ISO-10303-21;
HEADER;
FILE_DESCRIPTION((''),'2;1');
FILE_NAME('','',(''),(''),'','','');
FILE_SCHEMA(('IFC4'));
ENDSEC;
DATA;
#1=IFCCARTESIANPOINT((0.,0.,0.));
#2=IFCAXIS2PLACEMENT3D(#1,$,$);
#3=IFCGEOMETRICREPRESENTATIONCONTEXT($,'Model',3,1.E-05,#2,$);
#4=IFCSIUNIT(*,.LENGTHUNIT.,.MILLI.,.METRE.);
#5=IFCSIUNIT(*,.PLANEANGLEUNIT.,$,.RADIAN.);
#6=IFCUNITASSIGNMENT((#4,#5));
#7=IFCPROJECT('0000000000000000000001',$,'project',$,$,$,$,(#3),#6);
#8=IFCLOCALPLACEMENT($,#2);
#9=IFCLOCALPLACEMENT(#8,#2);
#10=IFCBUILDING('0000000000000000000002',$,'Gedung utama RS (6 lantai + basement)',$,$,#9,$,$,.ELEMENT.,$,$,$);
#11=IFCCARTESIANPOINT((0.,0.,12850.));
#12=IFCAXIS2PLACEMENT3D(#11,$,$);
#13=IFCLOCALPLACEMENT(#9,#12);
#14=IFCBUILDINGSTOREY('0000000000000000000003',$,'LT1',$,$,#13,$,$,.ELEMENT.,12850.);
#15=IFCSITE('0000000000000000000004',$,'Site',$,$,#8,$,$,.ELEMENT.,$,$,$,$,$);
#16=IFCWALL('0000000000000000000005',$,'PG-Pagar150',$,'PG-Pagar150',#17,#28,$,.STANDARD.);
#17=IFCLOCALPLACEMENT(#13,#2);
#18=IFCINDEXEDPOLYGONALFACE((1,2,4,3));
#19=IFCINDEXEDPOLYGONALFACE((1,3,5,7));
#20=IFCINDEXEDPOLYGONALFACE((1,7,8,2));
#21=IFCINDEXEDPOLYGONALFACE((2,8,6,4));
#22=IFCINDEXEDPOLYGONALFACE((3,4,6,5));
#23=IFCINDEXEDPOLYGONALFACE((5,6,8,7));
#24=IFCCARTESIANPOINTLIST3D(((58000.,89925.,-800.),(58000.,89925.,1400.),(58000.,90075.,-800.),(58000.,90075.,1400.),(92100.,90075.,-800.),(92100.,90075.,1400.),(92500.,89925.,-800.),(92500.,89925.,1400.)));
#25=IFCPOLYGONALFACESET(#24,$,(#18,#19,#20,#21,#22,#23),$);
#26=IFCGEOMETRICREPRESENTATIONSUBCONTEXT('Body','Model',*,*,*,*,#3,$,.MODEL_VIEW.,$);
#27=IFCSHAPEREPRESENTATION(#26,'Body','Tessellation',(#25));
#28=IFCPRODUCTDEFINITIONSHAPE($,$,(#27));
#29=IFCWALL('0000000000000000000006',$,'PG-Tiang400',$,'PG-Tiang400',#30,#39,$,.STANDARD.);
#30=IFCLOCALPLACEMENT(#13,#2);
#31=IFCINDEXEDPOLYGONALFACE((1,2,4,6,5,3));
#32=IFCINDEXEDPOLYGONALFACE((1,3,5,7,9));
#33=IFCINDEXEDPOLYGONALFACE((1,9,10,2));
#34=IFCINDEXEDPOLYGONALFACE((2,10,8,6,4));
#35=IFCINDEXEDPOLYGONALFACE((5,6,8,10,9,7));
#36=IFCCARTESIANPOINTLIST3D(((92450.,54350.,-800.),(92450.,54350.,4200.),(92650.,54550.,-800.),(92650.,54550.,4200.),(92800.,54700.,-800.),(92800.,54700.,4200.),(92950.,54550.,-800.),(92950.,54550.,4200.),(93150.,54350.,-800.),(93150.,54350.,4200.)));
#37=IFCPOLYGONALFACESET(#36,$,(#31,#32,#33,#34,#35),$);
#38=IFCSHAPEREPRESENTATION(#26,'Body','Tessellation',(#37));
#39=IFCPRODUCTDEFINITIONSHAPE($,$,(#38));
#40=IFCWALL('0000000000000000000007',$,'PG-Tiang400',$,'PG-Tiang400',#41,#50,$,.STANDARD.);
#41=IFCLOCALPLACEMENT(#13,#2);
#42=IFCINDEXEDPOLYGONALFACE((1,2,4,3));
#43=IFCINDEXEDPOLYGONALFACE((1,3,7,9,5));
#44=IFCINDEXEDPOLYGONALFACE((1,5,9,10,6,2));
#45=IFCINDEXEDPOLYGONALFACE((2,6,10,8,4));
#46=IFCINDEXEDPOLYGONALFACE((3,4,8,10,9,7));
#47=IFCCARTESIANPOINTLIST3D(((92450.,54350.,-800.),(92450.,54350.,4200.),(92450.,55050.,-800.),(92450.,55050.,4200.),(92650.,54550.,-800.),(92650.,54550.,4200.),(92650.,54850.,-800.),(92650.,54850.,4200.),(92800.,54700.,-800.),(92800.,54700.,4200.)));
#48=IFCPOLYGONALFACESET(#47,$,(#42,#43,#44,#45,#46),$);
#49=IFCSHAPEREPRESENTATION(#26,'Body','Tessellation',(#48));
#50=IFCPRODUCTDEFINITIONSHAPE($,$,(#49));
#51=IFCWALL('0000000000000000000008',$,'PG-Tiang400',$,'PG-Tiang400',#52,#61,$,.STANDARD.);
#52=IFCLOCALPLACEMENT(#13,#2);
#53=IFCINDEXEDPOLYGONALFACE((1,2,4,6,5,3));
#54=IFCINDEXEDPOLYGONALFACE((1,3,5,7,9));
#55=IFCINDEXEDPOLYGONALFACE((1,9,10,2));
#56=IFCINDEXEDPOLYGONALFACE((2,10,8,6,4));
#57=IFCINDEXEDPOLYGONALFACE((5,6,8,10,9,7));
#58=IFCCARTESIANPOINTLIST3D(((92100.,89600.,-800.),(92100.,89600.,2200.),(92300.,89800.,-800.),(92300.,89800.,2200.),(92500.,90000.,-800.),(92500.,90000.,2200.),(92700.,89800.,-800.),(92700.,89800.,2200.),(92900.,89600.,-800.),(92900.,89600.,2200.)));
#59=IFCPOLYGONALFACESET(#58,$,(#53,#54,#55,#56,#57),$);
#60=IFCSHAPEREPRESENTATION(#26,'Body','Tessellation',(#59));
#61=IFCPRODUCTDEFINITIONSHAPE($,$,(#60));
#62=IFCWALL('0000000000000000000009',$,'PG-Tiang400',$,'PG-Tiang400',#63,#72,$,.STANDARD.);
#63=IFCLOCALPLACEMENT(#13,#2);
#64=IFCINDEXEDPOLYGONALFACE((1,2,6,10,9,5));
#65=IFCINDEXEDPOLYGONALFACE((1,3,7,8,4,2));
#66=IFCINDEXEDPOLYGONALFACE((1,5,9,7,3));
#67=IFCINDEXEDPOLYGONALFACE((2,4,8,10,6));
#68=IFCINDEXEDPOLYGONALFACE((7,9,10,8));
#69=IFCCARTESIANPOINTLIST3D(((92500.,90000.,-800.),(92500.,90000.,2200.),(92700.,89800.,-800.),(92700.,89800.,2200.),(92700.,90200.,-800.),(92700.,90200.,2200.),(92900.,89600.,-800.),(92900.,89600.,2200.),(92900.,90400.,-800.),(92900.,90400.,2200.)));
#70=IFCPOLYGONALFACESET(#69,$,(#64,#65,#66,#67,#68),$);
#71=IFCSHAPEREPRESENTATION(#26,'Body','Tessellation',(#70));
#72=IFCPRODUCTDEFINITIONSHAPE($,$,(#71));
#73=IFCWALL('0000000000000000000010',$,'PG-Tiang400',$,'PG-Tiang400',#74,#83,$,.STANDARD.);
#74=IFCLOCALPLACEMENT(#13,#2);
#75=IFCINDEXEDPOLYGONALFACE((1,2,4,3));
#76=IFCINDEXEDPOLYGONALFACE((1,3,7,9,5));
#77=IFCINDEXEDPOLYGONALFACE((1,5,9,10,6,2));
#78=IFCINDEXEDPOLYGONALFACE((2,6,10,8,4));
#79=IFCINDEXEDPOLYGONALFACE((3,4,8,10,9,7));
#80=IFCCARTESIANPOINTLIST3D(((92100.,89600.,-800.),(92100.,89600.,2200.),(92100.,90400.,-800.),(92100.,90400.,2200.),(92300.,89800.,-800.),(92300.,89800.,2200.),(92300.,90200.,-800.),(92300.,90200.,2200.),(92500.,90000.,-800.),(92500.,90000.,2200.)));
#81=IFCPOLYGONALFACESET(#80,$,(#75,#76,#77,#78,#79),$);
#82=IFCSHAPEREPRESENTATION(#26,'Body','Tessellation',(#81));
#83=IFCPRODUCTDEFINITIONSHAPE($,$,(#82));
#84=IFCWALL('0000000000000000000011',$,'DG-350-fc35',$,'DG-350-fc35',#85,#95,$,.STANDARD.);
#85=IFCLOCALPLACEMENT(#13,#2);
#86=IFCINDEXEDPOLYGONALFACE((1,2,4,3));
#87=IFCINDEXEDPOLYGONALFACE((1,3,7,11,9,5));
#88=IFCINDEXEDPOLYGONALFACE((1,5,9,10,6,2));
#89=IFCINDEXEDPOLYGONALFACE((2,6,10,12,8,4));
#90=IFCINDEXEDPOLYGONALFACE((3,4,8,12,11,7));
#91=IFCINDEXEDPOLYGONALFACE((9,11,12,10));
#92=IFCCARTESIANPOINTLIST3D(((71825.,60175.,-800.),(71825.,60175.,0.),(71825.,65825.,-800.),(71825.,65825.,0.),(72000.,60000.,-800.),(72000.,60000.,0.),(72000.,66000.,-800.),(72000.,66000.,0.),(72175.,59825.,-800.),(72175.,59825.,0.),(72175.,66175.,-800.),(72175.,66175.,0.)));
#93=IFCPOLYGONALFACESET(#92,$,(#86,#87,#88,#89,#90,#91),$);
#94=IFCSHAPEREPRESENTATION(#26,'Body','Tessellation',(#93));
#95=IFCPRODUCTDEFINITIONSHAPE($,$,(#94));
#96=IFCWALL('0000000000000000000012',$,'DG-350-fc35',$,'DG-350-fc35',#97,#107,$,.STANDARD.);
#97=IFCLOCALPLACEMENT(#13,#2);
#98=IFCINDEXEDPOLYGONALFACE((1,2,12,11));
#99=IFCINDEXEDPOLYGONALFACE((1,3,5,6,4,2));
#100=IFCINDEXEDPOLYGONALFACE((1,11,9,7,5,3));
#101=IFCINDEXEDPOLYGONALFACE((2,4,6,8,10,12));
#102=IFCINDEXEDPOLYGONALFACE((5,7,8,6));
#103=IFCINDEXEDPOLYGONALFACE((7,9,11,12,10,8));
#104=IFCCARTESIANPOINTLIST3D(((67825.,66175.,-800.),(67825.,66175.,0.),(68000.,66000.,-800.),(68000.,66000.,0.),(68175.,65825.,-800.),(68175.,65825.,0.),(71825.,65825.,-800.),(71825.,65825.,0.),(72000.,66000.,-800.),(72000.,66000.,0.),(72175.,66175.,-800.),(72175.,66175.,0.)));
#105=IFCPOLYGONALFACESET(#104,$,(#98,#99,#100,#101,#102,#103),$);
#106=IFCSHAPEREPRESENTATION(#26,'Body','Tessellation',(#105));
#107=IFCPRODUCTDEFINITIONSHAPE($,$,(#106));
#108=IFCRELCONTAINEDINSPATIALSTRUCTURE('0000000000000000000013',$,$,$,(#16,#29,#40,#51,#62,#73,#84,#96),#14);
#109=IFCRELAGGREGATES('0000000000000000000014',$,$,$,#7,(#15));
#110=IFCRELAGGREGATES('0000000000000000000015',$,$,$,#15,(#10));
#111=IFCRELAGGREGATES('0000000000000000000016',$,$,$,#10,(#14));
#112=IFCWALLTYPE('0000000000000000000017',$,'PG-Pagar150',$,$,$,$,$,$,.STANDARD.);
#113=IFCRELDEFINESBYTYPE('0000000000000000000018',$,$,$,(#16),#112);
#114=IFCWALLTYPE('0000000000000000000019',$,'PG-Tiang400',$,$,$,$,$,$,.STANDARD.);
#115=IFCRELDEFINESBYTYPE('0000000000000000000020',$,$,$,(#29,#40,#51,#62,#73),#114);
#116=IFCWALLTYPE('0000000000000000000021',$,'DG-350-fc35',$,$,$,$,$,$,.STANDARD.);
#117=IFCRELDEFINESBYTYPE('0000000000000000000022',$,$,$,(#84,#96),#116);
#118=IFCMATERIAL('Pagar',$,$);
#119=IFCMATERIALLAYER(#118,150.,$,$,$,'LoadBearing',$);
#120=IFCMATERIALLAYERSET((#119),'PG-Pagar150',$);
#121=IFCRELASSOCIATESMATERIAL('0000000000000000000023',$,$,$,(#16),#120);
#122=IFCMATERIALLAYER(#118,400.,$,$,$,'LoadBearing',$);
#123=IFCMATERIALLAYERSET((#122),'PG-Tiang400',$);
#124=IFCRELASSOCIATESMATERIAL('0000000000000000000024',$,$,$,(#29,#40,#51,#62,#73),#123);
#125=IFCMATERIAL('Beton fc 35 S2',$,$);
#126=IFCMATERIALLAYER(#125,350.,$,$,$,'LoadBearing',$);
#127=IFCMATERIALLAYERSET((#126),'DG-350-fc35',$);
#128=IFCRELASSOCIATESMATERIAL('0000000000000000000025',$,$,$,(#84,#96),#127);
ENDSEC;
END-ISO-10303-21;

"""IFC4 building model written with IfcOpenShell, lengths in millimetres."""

from ifc_helpers import new_model, si_unit, frame, origin, place, context, subcontext, project, spatial, polyline, outline, extrude, material, layer, layer_set, layer_usage, type_object, element, save


model = new_model("IFC4")

# Units and contexts
model_context = context("Model", 3, precision=1e-05, world=origin())
body_context = subcontext(model_context, "Body", "Model", "MODEL_VIEW")
ifc_project = project(units=[si_unit("LENGTHUNIT", "METRE", prefix="MILLI"), si_unit("PLANEANGLEUNIT", "RADIAN")], contexts=[model_context])

# Site, building, storey
site_placement = place(None, origin())
site = spatial("IfcSite", under=ifc_project, at=site_placement, Name="Site", CompositionType="ELEMENT")
building_placement = place(site_placement, origin())
building = spatial("IfcBuilding", under=site, at=building_placement, Name="Gedung utama RS (6 lantai + basement)", CompositionType="ELEMENT")
storey_placement = place(building_placement, frame((0.0, 0.0, 12850.0)))
storey = spatial("IfcBuildingStorey", under=building, at=storey_placement, Name="LT1", CompositionType="ELEMENT", Elevation=12850.0)

# Shared definitions
ifc_material_1 = material(Name="Beton fc 35 S2")

# Walls
ifc_material_2 = material(Name="Pagar")
ifc_layer_1 = layer(ifc_material_2, 150.0, Category="LoadBearing")
ifc_layer_set_1 = layer_set([ifc_layer_1], Name="PG-Pagar150")
ifc_layer_usage_1 = layer_usage(ifc_layer_set_1, "AXIS2", "NEGATIVE", 75.0)
wall_type_1 = type_object("IfcWallType", Name="PG-Pagar150", PredefinedType="STANDARD")
wall_1_placement = place(storey_placement, frame((92500.0, 90000.0, -800.0), z_axis=(0.0, 0.0, 1.0), x_axis=(-1.0, 0.0, 0.0)))
element("IfcWall", 1, at=wall_1_placement, inside=storey, type_object=wall_type_1, material=ifc_layer_usage_1, Name="PG-Pagar150", ObjectType="PG-Pagar150", PredefinedType="STANDARD", context=body_context, shape_type="SweptSolid", body=[
    extrude(outline(polyline([(400.0, -75.0), (0.0, 75.0), (34500.0, 75.0), (34500.0, -75.0), (400.0, -75.0)])), origin(), (0.0, 0.0, 1.0), 2200.0),
])
ifc_layer_2 = layer(ifc_material_2, 400.0, Category="LoadBearing")
ifc_layer_set_2 = layer_set([ifc_layer_2], Name="PG-Tiang400")
ifc_layer_usage_2 = layer_usage(ifc_layer_set_2, "AXIS2", "NEGATIVE", 200.0)
wall_type_2 = type_object("IfcWallType", Name="PG-Tiang400", PredefinedType="STANDARD")
for number, where, z_axis, x_axis, name in (
    (2, (92650.0, 54550.0, -800.0), (0.0, 0.0, 1.0), (1.0, 0.0, 0.0), "PG-Tiang400"),
    (3, (92650.0, 54850.0, -800.0), (0.0, 0.0, 1.0), (0.0, -1.0, 0.0), "PG-Tiang400"),
):
    element("IfcWall", number, at=place(storey_placement, frame(where, z_axis=z_axis, x_axis=x_axis)), inside=storey, type_object=wall_type_2, material=ifc_layer_usage_2, Name=name, ObjectType="PG-Tiang400", PredefinedType="STANDARD", context=body_context, shape_type="SweptSolid", body=[
        extrude(outline(polyline([(-200.0, -200.0), (0.0, 0.0), (200.0, 200.0), (100.0, 200.0), (300.0, 0.0), (500.0, -200.0), (-200.0, -200.0)])), origin(), (0.0, 0.0, 1.0), 5000.0),
    ])
for number, where, z_axis, x_axis, name in (
    (4, (92300.0, 89800.0, -800.0), (0.0, 0.0, 1.0), (1.0, 0.0, 0.0), "PG-Tiang400"),
    (5, (92700.0, 89800.0, -800.0), (0.0, 0.0, 1.0), (0.0, 1.0, 0.0), "PG-Tiang400"),
    (6, (92300.0, 90200.0, -800.0), (0.0, 0.0, 1.0), (0.0, -1.0, 0.0), "PG-Tiang400"),
):
    element("IfcWall", number, at=place(storey_placement, frame(where, z_axis=z_axis, x_axis=x_axis)), inside=storey, type_object=wall_type_2, material=ifc_layer_usage_2, Name=name, ObjectType="PG-Tiang400", PredefinedType="STANDARD", context=body_context, shape_type="SweptSolid", body=[
        extrude(outline(polyline([(-200.0, -200.0), (0.0, 0.0), (200.0, 200.0), (400.0, 0.0), (600.0, -200.0), (-200.0, -200.0)])), origin(), (0.0, 0.0, 1.0), 3000.0),
    ])
ifc_layer_3 = layer(ifc_material_1, 350.0, Category="LoadBearing")
ifc_layer_set_3 = layer_set([ifc_layer_3], Name="DG-350-fc35")
ifc_layer_usage_3 = layer_usage(ifc_layer_set_3, "AXIS2", "NEGATIVE", 175.0)
wall_type_3 = type_object("IfcWallType", Name="DG-350-fc35", PredefinedType="STANDARD")
wall_2_placement = place(storey_placement, frame((72000.0, 60000.0, -800.0), z_axis=(0.0, 0.0, 1.0), x_axis=(0.0, 1.0, 0.0)))
element("IfcWall", 7, at=wall_2_placement, inside=storey, type_object=wall_type_3, material=ifc_layer_usage_3, Name="DG-350-fc35", ObjectType="DG-350-fc35", PredefinedType="STANDARD", context=body_context, shape_type="SweptSolid", body=[
    extrude(outline(polyline([(-175.0, -175.0), (0.0, 0.0), (175.0, 175.0), (5825.0, 175.0), (6000.0, 0.0), (6175.0, -175.0), (-175.0, -175.0)])), origin(), (0.0, 0.0, 1.0), 800.0),
])
wall_3_placement = place(storey_placement, frame((72000.0, 66000.0, -800.0), z_axis=(0.0, 0.0, 1.0), x_axis=(-1.0, 0.0, 0.0)))
element("IfcWall", 8, at=wall_3_placement, inside=storey, type_object=wall_type_3, material=ifc_layer_usage_3, Name="DG-350-fc35", ObjectType="DG-350-fc35", PredefinedType="STANDARD", context=body_context, shape_type="SweptSolid", body=[
    extrude(outline(polyline([(-175.0, -175.0), (0.0, 0.0), (175.0, 175.0), (3825.0, 175.0), (4000.0, 0.0), (4175.0, -175.0), (-175.0, -175.0)])), origin(), (0.0, 0.0, 1.0), 800.0),
])

save(model, "model.ifc")
